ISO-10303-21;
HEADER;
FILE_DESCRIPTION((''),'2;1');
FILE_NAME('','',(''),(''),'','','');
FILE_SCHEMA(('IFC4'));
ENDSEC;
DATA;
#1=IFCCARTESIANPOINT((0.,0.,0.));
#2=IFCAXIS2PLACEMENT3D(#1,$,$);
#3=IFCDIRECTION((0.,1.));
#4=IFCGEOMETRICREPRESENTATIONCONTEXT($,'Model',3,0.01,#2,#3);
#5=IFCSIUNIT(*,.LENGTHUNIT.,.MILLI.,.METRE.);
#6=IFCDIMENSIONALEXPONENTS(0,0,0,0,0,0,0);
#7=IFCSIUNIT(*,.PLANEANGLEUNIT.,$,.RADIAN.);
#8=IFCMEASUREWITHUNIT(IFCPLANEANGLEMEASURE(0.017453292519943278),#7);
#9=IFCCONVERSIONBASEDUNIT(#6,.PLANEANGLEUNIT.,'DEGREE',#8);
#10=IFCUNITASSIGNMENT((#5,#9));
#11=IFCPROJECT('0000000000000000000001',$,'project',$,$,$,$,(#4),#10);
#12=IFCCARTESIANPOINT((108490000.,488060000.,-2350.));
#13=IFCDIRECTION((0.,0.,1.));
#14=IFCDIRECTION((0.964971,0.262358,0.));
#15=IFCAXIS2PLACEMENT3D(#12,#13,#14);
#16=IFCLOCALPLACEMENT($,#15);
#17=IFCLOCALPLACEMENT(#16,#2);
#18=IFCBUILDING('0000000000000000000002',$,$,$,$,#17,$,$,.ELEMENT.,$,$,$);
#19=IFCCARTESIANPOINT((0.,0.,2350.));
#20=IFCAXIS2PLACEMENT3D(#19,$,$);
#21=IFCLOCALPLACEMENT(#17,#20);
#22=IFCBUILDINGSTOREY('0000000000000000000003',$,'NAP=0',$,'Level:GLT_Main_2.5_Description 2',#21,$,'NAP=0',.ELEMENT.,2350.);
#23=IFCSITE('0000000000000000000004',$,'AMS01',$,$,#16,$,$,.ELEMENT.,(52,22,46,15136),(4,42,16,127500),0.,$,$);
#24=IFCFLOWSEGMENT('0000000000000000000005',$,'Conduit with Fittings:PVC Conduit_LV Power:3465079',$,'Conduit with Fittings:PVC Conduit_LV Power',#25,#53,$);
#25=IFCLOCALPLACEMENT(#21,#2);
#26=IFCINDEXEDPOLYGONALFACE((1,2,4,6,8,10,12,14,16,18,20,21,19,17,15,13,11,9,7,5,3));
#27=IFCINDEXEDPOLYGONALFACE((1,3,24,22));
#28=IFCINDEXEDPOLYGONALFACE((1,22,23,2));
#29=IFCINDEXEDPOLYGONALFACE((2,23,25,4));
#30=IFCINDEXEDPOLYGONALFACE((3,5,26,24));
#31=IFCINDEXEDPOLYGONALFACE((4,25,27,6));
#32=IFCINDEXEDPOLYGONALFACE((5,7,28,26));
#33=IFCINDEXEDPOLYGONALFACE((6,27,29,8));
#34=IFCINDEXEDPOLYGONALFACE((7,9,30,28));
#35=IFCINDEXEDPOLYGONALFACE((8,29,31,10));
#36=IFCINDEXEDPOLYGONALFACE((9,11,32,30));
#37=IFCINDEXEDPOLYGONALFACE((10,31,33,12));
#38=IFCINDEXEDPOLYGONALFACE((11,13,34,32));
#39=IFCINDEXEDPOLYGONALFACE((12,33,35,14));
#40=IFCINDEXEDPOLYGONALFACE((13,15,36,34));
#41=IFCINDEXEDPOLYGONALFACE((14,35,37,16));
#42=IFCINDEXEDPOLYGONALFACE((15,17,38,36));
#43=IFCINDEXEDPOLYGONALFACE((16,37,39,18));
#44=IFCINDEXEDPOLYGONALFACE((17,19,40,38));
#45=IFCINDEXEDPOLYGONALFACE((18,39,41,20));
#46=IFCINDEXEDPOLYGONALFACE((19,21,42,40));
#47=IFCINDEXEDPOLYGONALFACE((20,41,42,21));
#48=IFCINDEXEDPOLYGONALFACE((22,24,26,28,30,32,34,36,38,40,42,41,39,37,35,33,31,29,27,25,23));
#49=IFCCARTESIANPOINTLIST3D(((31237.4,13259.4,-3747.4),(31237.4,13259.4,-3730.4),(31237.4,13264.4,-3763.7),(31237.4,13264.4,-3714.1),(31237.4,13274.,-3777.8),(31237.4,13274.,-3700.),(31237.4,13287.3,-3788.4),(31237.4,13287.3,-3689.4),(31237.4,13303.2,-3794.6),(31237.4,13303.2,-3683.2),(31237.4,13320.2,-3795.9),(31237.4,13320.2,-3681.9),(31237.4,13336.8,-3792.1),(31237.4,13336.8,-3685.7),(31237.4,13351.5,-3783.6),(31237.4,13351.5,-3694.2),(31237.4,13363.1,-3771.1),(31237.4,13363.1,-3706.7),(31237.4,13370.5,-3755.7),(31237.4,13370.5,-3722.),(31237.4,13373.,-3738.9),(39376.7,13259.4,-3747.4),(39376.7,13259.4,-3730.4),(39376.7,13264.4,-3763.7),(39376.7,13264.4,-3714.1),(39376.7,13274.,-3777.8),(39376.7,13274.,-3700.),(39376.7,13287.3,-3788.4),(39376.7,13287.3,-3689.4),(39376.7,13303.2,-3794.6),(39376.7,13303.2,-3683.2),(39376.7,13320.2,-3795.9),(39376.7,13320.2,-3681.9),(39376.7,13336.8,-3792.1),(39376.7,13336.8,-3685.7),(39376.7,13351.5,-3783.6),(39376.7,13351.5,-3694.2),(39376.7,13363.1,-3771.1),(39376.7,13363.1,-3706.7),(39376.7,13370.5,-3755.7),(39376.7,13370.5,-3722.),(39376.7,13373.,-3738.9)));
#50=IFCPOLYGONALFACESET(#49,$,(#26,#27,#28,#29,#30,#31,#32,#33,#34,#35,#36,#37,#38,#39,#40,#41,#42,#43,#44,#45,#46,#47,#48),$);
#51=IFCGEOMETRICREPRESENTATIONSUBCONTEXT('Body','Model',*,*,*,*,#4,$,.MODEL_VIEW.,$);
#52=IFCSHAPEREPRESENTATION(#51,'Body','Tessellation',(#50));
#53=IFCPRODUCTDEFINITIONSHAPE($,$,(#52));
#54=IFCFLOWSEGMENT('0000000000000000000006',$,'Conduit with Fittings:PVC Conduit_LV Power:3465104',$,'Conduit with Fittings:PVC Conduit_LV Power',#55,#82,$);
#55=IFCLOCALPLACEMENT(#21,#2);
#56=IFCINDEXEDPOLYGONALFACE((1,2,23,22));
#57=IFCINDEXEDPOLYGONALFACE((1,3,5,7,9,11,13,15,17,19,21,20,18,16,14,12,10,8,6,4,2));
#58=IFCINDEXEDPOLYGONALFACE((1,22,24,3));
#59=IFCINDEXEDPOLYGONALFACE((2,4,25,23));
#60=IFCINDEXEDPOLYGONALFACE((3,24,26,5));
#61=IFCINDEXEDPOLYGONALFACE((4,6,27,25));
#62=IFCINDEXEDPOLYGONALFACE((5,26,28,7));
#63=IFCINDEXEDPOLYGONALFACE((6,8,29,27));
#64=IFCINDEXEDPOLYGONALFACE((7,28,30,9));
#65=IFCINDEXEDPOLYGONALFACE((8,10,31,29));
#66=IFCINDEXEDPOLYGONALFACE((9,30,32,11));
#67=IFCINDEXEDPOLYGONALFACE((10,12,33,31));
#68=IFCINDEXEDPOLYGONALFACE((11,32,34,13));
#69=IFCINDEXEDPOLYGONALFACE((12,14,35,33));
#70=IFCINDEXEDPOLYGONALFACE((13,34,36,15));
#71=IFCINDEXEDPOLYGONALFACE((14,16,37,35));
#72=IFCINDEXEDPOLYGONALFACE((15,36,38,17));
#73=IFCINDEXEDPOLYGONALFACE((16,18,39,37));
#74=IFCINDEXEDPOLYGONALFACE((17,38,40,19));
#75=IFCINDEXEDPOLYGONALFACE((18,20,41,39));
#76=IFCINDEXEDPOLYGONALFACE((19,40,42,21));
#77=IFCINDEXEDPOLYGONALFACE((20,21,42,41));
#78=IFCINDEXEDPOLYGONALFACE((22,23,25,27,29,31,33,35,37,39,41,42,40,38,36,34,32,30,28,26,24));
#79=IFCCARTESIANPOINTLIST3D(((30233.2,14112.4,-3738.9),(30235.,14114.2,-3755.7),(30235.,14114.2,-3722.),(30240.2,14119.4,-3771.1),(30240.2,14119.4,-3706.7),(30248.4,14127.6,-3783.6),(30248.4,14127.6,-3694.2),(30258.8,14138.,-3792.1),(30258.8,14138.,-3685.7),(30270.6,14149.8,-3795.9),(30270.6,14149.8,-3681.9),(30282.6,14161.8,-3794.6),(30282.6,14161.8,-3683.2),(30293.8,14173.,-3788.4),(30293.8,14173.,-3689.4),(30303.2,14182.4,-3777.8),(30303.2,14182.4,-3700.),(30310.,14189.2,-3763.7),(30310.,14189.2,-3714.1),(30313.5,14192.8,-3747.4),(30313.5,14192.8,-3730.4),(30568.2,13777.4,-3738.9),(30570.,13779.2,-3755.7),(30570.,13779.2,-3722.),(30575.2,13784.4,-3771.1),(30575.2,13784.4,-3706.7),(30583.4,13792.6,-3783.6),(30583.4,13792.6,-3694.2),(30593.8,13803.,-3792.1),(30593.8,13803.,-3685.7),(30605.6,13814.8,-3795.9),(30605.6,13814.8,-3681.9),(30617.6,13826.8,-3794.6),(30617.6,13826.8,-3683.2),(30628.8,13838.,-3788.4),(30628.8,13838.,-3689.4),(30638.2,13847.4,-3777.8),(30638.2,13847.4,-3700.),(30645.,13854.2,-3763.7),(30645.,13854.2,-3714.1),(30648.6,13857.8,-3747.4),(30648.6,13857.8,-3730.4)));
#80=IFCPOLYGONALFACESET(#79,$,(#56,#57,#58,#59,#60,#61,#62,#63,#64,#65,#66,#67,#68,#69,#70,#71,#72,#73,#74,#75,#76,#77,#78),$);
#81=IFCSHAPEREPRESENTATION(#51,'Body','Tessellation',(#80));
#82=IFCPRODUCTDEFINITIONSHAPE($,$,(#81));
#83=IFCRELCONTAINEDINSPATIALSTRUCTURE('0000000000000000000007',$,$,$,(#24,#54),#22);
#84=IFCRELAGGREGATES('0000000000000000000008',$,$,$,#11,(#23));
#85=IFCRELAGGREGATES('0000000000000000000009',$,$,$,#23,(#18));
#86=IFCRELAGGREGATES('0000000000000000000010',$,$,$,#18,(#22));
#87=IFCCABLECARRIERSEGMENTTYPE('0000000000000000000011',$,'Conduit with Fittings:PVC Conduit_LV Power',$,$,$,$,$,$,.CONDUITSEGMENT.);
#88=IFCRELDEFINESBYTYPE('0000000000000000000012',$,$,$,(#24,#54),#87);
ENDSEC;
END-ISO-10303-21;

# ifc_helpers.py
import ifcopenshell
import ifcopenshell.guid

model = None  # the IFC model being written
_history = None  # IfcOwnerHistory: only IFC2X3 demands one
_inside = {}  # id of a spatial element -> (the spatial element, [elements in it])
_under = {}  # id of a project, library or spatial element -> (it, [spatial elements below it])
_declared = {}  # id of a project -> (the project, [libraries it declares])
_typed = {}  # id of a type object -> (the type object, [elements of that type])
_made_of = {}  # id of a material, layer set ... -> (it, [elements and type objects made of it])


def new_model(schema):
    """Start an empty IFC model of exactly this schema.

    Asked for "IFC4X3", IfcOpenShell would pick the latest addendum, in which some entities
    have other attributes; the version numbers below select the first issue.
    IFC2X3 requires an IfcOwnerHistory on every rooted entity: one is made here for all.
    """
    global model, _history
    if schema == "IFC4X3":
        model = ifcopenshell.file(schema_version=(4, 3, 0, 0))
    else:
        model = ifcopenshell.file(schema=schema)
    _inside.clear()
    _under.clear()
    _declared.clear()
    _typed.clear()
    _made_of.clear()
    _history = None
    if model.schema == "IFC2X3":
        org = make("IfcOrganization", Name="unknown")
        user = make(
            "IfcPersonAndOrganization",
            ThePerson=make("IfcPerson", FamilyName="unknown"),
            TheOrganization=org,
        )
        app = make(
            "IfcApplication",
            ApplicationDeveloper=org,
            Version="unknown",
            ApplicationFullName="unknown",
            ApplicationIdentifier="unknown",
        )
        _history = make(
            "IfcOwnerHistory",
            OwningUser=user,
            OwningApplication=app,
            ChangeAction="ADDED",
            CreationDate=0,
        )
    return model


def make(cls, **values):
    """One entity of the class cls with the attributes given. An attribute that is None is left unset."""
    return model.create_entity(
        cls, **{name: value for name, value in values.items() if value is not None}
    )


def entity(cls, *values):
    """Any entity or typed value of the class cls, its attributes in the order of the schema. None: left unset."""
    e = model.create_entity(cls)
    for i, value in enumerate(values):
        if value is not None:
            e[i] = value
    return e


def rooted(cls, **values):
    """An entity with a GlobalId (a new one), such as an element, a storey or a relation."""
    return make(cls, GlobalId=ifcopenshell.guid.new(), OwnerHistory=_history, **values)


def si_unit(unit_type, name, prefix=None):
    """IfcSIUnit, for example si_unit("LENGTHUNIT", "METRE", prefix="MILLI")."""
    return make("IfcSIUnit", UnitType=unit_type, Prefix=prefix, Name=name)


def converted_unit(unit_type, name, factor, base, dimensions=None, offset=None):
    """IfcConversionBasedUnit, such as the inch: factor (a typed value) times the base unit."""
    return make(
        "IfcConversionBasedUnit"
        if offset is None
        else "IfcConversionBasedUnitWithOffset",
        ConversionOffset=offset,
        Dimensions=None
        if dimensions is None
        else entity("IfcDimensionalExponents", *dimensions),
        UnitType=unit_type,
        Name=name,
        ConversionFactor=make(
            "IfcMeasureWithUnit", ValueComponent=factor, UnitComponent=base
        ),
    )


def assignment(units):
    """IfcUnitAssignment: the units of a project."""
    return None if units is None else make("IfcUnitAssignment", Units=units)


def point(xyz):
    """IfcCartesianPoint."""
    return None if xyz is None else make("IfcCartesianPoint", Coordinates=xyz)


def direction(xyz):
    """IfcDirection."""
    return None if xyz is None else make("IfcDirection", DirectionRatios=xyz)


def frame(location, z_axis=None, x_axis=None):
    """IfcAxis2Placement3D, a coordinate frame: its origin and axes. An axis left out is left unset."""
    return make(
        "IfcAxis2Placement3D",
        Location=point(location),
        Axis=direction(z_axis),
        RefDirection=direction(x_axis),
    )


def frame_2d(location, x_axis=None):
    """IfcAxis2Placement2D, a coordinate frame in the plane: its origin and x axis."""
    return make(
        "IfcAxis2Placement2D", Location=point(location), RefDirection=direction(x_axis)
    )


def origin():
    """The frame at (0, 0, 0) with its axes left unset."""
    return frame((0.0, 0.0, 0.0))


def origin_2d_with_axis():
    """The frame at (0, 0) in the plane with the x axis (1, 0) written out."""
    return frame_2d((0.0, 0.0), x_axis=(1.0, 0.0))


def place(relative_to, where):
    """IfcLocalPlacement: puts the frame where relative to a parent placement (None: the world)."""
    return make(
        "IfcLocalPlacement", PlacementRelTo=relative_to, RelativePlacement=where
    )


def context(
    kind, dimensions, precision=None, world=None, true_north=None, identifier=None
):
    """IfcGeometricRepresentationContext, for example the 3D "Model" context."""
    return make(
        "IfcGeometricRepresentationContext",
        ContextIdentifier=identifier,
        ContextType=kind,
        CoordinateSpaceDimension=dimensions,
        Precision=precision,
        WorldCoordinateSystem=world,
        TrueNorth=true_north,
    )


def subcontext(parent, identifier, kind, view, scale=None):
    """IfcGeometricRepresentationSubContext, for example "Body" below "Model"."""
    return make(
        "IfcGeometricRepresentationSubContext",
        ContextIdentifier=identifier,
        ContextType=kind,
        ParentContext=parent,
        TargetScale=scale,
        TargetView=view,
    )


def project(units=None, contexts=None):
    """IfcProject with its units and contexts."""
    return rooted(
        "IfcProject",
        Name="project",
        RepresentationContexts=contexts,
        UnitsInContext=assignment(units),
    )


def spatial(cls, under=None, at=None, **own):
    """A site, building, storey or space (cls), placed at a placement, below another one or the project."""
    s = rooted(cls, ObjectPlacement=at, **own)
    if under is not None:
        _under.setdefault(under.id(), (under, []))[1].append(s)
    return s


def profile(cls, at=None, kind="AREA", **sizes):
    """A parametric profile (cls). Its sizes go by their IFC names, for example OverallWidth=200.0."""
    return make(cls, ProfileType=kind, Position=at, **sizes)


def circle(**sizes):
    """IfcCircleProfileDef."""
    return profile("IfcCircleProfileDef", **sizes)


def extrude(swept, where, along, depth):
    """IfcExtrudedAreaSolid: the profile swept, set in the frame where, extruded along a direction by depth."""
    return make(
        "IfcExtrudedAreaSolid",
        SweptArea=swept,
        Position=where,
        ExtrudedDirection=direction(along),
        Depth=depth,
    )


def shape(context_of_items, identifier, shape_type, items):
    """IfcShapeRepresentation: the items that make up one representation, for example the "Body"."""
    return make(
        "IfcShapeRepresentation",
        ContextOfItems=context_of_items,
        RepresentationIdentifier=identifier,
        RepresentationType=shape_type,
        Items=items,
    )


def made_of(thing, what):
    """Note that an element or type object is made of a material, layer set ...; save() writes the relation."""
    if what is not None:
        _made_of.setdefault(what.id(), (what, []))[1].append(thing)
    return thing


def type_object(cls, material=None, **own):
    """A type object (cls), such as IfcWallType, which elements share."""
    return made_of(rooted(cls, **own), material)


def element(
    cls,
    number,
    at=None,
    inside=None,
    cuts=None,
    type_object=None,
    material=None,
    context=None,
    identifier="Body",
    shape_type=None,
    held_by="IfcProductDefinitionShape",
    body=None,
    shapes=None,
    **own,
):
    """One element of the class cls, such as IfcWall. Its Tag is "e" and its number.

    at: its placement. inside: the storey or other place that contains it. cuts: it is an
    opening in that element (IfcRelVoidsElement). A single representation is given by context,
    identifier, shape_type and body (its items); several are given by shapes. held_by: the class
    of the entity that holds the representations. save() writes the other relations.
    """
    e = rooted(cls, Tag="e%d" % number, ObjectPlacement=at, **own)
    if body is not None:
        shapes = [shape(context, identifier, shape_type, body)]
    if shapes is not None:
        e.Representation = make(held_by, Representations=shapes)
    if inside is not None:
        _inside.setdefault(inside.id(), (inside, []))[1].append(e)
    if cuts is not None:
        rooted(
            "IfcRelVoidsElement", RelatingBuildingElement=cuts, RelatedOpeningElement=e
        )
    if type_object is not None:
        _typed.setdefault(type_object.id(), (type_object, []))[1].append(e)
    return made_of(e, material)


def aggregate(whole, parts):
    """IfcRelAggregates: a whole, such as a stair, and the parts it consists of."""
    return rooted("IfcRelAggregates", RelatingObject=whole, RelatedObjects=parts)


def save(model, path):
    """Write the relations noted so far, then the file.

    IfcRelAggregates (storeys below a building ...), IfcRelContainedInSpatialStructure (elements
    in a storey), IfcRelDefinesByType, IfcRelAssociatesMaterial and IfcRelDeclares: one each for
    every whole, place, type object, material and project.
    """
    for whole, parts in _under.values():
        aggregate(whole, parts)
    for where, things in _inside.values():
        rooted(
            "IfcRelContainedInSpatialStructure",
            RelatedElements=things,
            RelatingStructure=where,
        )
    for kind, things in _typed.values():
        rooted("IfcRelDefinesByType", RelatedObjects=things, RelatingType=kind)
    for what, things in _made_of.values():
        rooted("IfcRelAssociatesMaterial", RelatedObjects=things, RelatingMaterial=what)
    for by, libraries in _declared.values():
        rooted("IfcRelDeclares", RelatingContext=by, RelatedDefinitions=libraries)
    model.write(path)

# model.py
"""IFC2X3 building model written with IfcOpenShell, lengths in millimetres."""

from ifc_helpers import new_model, entity, si_unit, converted_unit, direction, frame, frame_2d, origin, origin_2d_with_axis, place, context, subcontext, project, spatial, circle, extrude, type_object, element, save


model = new_model("IFC2X3")

# Units and contexts
model_context = context("Model", 3, precision=0.01, world=origin(), true_north=direction((0.0, 1.0)))
body_context = subcontext(model_context, "Body", "Model", "MODEL_VIEW")
ifc_project = project(units=[si_unit("LENGTHUNIT", "METRE", prefix="MILLI"), converted_unit("PLANEANGLEUNIT", "DEGREE", entity("IfcPlaneAngleMeasure", 0.017453292519943278), si_unit("PLANEANGLEUNIT", "RADIAN"), dimensions=[0, 0, 0, 0, 0, 0, 0])], contexts=[model_context])

# Site, building, storey
site_placement = place(None, frame((108490000.0, 488060000.0, -2350.0), z_axis=(0.0, 0.0, 1.0), x_axis=(0.964971, 0.262358, 0.0)))
site = spatial("IfcSite", under=ifc_project, at=site_placement, Name="AMS01", CompositionType="ELEMENT", RefLatitude=(52, 22, 46, 15136), RefLongitude=(4, 42, 16, 127500), RefElevation=0.0)
building_placement = place(site_placement, origin())
building = spatial("IfcBuilding", under=site, at=building_placement, CompositionType="ELEMENT")
storey_placement = place(building_placement, frame((0.0, 0.0, 2350.0)))
storey = spatial("IfcBuildingStorey", under=building, at=storey_placement, Name="NAP=0", ObjectType="Level:GLT_Main_2.5_Description 2", LongName="NAP=0", CompositionType="ELEMENT", Elevation=2350.0)

# Flow segments
cable_carrier_segment_type = type_object("IfcCableCarrierSegmentType", Name="Conduit with Fittings:PVC Conduit_LV Power", PredefinedType="CONDUITSEGMENT")
flow_segment_1_placement = place(storey_placement, origin())
element("IfcFlowSegment", 1, at=flow_segment_1_placement, inside=storey, type_object=cable_carrier_segment_type, Name="Conduit with Fittings:PVC Conduit_LV Power:3465079", ObjectType="Conduit with Fittings:PVC Conduit_LV Power", context=body_context, shape_type="SweptSolid", body=[
    extrude(circle(Radius=57.2, at=frame_2d((0.0, 0.0), x_axis=(1.0, 0.0))), frame((31237.4, 13315.9, -3738.9), z_axis=(1.0, 0.0, 0.0), x_axis=(0.0, 1.0, 0.0)), (0.0, 0.0, 1.0), 8139.3),
])
flow_segment_2_placement = place(storey_placement, origin())
element("IfcFlowSegment", 2, at=flow_segment_2_placement, inside=storey, type_object=cable_carrier_segment_type, Name="Conduit with Fittings:PVC Conduit_LV Power:3465104", ObjectType="Conduit with Fittings:PVC Conduit_LV Power", context=body_context, shape_type="SweptSolid", body=[
    extrude(circle(Radius=57.2, at=origin_2d_with_axis()), frame((30273.6, 14152.8, -3738.9), z_axis=(0.707107, -0.707107, 0.0), x_axis=(-0.707107, -0.707107, 0.0)), (0.0, 0.0, 1.0), 473.8),
])

save(model, "model.ifc")
